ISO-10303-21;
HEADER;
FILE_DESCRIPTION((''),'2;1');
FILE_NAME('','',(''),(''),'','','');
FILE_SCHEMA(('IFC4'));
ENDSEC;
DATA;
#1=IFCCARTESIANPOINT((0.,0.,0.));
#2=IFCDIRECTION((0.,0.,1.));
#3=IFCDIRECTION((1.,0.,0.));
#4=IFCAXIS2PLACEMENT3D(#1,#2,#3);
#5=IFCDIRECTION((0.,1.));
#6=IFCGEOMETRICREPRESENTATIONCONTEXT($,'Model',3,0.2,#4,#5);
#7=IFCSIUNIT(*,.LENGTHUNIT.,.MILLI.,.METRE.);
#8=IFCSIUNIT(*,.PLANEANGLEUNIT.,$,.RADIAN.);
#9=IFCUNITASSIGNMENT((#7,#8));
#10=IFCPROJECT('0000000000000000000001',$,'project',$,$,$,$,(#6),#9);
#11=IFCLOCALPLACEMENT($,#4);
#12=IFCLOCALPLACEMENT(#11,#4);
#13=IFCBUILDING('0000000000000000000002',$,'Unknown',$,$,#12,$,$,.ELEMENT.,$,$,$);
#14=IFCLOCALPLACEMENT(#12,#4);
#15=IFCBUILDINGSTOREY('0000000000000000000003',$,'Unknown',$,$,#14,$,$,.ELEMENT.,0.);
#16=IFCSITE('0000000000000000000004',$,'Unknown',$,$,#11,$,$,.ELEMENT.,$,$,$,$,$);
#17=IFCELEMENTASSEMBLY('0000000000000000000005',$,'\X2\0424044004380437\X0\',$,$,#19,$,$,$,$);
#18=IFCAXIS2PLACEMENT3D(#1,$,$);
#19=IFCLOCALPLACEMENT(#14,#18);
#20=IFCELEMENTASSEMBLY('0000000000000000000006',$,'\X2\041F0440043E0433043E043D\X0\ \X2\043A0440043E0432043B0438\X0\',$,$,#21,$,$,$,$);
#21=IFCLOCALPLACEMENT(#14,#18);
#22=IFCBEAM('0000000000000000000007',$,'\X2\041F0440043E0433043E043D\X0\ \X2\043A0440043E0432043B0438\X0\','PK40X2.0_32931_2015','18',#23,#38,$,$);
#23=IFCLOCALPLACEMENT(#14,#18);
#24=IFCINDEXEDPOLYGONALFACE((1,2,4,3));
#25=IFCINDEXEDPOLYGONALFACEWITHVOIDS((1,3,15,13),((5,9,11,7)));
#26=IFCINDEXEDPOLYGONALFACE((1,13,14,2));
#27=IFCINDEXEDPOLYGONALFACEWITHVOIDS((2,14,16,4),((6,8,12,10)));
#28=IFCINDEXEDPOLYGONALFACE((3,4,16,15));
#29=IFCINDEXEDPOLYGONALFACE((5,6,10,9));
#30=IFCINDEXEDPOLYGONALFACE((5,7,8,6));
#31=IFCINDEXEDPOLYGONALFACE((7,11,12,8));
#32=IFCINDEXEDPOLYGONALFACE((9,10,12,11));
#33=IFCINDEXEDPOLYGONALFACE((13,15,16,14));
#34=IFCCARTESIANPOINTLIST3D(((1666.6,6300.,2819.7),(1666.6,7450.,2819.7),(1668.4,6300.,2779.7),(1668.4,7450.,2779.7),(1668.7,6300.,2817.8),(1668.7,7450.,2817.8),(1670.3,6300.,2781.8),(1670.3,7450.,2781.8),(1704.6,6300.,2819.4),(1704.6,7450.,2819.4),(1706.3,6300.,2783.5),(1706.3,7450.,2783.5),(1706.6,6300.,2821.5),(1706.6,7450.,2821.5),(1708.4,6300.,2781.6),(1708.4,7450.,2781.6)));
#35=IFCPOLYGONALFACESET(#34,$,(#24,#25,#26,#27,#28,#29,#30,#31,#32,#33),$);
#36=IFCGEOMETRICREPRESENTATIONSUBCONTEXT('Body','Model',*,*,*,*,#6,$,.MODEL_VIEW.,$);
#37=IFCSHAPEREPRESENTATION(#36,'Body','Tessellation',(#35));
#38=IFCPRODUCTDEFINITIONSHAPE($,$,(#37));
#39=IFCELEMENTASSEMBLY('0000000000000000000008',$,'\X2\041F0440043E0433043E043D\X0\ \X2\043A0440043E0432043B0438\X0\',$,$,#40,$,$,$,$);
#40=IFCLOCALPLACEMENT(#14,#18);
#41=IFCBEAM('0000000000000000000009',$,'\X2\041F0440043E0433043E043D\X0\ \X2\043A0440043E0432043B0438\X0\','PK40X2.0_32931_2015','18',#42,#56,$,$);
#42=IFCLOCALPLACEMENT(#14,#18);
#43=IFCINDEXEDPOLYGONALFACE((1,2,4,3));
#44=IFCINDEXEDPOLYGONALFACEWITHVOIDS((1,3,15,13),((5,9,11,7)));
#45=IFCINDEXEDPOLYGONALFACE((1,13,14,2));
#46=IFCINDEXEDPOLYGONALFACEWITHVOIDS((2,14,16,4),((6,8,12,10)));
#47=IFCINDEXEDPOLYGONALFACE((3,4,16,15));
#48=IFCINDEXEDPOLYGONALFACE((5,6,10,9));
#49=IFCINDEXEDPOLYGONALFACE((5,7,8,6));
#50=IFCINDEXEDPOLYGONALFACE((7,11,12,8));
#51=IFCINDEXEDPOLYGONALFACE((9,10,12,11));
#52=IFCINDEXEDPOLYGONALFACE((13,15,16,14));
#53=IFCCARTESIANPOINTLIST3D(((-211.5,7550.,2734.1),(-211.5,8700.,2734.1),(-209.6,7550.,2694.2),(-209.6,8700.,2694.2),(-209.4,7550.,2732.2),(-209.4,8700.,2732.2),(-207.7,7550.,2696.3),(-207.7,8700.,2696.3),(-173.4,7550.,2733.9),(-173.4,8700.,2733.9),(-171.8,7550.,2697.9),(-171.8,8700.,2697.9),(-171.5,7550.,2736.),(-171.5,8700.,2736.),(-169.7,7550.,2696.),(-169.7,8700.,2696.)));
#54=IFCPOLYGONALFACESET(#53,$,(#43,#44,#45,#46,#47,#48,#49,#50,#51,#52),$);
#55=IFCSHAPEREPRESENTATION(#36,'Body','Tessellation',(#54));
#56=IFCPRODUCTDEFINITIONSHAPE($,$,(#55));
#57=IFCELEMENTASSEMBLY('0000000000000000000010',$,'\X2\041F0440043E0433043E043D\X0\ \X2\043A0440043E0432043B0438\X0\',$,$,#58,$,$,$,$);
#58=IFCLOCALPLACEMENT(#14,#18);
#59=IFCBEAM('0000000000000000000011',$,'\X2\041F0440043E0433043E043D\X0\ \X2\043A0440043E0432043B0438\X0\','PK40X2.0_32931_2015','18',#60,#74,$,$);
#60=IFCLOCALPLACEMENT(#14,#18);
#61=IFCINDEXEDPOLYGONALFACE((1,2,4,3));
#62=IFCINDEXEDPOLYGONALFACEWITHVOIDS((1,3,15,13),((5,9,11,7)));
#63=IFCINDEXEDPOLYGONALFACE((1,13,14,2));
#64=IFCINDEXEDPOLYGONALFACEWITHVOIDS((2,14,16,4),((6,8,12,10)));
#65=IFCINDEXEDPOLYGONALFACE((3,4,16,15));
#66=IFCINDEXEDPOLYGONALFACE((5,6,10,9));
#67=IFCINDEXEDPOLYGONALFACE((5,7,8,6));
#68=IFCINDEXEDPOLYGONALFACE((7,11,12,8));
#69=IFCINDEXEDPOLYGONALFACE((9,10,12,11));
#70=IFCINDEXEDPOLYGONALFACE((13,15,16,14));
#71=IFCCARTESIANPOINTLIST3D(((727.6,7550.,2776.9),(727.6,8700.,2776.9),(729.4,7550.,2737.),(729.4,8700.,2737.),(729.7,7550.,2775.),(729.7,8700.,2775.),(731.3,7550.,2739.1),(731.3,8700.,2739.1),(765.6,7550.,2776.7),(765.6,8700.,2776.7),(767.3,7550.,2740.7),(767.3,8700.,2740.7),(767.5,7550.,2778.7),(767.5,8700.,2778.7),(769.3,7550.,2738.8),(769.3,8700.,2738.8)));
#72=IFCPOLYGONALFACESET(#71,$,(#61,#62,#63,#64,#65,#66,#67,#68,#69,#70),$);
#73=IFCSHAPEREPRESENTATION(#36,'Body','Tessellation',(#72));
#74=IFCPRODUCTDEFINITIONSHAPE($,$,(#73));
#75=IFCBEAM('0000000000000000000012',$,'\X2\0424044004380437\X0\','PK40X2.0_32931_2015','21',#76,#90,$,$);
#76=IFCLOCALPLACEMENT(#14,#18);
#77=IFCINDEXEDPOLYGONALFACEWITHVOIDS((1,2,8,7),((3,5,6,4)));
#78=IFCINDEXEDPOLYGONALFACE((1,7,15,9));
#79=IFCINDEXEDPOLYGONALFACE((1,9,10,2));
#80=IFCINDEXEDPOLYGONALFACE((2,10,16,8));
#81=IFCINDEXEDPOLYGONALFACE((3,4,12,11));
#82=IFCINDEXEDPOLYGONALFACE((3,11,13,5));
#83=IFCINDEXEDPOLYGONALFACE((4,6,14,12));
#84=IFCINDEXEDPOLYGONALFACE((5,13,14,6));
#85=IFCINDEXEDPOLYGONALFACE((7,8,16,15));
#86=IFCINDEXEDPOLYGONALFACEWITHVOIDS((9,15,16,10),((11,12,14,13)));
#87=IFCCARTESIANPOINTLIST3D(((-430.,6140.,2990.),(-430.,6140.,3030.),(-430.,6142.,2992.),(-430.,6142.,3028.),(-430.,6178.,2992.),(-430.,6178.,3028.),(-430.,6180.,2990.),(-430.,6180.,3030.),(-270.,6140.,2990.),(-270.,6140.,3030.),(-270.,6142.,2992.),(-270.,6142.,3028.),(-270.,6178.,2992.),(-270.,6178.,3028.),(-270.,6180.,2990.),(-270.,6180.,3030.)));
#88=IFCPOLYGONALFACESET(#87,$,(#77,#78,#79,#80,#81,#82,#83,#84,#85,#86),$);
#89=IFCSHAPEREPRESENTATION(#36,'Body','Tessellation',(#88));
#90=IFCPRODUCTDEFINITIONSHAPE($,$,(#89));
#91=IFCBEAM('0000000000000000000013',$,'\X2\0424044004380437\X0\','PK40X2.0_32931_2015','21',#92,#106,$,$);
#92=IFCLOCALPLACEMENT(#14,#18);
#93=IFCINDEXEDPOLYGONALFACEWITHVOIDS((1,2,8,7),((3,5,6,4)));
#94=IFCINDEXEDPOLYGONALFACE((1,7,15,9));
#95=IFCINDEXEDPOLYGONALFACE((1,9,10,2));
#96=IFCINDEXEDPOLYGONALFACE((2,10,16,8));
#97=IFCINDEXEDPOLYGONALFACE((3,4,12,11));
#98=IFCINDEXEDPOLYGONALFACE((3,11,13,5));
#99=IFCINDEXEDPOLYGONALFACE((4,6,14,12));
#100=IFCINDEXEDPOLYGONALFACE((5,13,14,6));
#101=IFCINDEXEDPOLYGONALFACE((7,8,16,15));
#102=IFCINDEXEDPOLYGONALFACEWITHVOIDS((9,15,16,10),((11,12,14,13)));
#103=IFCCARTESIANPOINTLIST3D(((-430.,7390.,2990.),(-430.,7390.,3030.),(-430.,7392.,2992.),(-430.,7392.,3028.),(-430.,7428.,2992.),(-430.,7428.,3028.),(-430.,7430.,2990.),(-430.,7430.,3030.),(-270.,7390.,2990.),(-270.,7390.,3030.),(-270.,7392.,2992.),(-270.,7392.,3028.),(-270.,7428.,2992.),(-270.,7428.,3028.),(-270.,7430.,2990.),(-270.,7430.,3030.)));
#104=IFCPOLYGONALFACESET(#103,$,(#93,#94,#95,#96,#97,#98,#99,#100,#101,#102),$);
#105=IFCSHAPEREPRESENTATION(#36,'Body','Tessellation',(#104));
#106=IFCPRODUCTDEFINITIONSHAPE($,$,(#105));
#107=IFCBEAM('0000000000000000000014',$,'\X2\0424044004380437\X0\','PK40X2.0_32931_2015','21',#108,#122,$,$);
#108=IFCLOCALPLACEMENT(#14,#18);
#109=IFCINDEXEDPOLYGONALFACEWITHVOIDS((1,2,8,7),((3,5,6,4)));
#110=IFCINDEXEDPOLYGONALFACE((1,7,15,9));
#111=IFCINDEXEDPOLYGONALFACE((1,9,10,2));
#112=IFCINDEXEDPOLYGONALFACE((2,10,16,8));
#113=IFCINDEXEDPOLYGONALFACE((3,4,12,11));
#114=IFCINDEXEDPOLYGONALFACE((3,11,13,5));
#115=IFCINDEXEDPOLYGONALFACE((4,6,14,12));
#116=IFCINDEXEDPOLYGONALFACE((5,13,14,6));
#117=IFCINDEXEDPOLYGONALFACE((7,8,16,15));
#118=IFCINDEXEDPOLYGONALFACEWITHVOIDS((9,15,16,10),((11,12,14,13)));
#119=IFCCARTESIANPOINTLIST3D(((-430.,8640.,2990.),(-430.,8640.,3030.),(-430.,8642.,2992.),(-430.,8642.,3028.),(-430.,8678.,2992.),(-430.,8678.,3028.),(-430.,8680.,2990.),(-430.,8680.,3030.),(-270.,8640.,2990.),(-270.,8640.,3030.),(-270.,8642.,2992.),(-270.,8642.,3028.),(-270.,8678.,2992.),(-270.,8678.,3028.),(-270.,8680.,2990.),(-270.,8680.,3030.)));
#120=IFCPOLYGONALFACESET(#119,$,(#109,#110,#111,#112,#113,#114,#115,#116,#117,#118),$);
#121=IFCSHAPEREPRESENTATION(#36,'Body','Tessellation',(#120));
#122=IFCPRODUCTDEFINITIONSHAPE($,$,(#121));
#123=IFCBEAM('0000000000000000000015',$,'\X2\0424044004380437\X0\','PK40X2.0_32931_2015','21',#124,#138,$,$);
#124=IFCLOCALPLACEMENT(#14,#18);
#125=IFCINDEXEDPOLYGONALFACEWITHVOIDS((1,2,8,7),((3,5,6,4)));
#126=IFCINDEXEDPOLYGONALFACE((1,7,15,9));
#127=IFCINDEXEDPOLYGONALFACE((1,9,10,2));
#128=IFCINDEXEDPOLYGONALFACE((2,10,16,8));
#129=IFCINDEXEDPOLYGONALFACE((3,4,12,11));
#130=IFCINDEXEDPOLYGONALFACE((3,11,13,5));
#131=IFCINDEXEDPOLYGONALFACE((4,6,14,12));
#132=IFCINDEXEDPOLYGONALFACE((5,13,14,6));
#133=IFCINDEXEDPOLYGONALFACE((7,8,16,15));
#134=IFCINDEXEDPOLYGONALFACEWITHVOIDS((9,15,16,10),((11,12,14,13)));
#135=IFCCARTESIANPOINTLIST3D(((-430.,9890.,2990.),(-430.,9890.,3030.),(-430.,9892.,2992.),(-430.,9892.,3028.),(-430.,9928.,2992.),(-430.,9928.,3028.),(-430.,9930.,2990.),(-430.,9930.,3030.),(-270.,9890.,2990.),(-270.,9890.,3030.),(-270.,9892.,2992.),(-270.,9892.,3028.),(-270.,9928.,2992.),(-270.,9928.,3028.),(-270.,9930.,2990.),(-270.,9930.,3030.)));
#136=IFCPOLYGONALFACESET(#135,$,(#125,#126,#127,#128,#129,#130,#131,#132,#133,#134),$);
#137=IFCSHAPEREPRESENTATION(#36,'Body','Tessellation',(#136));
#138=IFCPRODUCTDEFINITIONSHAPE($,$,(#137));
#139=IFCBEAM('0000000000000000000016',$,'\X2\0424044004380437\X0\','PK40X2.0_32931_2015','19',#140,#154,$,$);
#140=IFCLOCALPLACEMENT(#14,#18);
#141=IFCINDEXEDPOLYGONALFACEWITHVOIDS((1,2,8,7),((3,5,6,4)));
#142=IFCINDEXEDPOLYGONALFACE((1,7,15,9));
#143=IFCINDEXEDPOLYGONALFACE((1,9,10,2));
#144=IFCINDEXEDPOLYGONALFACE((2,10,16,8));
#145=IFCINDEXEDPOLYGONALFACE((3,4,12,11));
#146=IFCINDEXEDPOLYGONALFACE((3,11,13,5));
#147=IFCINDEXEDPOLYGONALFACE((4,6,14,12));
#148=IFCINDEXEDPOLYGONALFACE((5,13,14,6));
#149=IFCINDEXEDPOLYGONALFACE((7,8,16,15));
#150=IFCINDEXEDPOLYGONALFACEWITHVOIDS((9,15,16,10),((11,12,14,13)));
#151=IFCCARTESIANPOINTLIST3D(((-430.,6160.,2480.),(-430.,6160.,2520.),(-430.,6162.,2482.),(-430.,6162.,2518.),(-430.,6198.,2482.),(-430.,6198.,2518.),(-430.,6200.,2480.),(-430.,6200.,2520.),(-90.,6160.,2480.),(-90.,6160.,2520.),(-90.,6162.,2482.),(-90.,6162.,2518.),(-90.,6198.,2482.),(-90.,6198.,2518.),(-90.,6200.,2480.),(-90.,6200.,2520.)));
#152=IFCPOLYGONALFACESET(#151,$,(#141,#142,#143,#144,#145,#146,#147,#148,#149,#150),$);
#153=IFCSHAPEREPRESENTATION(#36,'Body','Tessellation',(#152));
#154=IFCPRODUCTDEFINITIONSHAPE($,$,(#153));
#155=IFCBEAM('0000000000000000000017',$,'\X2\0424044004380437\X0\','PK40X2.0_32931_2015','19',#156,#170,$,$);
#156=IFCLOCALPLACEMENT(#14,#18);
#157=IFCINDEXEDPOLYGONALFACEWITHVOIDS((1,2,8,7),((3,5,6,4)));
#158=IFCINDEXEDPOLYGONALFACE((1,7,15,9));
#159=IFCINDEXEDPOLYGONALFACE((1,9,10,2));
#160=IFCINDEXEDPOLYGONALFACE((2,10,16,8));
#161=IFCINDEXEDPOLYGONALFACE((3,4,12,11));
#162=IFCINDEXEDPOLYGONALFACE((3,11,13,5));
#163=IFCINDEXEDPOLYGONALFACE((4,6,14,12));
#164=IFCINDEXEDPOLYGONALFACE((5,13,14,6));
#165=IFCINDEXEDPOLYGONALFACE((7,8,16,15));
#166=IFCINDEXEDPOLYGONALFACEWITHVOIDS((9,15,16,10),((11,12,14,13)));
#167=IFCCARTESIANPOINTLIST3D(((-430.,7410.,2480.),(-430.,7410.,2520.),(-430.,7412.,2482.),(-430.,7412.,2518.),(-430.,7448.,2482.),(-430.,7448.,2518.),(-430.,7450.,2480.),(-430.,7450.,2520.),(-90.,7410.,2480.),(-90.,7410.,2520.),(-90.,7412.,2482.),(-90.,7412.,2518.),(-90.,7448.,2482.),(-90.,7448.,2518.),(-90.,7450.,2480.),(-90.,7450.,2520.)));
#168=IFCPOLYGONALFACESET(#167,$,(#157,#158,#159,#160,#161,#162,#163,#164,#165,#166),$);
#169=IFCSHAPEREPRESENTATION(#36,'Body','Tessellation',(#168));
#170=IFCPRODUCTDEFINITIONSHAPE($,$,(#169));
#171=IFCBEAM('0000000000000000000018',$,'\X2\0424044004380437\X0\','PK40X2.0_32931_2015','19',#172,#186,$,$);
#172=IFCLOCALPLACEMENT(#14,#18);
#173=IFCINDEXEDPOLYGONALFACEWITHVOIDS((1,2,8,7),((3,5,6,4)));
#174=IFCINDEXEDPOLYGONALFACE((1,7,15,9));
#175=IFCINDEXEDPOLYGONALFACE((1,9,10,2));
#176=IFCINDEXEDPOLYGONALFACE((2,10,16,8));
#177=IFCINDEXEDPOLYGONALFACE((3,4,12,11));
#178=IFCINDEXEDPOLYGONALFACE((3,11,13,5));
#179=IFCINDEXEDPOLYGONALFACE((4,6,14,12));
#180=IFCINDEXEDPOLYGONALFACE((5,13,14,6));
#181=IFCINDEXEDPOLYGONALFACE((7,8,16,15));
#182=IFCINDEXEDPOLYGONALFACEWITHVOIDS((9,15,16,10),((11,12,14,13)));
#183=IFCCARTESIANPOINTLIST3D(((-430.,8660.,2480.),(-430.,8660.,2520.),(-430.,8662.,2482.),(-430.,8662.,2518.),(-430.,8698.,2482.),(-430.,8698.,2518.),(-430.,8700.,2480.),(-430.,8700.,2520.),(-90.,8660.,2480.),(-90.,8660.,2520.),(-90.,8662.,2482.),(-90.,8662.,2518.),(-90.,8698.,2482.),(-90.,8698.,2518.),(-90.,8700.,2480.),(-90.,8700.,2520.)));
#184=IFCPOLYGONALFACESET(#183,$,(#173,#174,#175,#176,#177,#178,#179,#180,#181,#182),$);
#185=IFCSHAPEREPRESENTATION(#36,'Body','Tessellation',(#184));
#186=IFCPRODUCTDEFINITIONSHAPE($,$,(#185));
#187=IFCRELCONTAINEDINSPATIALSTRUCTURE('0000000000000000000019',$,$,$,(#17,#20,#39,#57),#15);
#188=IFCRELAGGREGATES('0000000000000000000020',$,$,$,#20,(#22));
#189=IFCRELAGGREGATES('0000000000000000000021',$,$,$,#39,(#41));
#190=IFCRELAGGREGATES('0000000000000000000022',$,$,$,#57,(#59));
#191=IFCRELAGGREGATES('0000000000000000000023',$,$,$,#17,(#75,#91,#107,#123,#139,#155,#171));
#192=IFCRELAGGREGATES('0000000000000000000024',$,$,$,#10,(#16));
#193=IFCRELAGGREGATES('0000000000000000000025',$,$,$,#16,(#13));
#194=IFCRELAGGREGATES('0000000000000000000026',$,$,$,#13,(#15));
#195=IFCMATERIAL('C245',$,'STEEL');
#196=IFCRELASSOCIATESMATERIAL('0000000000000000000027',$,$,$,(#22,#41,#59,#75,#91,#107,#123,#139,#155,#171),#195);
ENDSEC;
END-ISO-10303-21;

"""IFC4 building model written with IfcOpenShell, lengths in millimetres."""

from ifc_helpers import new_model, si_unit, direction, frame, origin_with_axes, place, context, subcontext, project, spatial, line, indexed_curve, outline, extrude, material, element, aggregate, save


model = new_model("IFC4")

# Units and contexts
model_context = context("Model", 3, precision=0.2, world=origin_with_axes(), true_north=direction((0.0, 1.0)))
body_context = subcontext(model_context, "Body", "Model", "MODEL_VIEW")
ifc_project = project(units=[si_unit("LENGTHUNIT", "METRE", prefix="MILLI"), si_unit("PLANEANGLEUNIT", "RADIAN")], contexts=[model_context])

# Site, building, storey
site_placement = place(None, origin_with_axes())
site = spatial("IfcSite", under=ifc_project, at=site_placement, Name="Unknown", CompositionType="ELEMENT")
building_placement = place(site_placement, origin_with_axes())
building = spatial("IfcBuilding", under=site, at=building_placement, Name="Unknown", CompositionType="ELEMENT")
storey_placement = place(building_placement, origin_with_axes())
storey = spatial("IfcBuildingStorey", under=building, at=storey_placement, Name="Unknown", CompositionType="ELEMENT", Elevation=0.0)

# Element assembly
assembly_1_placement = place(storey_placement, frame((-450.0, -500.0, 3010.0), z_axis=(1.0, 0.0, 0.0), x_axis=(0.0, 1.0, 0.0)))
assembly_1 = element("IfcElementAssembly", 1, at=assembly_1_placement, inside=storey, Name="Фриз")
ifc_material = material(Name="C245", Category="STEEL")

# Element assemblies, beams
assembly_2_placement = place(storey_placement, frame((1687.5, 7450.0, 2800.6), z_axis=(-0.998964, 0.0, -0.045508), x_axis=(0.0, -1.0, 0.0)))
assembly_2 = element("IfcElementAssembly", 2, at=assembly_2_placement, inside=storey, Name="Прогон кровли")
beam_1_placement = place(assembly_2_placement, origin_with_axes())
beam_1 = element("IfcBeam", 3, at=beam_1_placement, material=ifc_material, Name="Прогон кровли", Description="PK40X2.0_32931_2015", ObjectType="18", context=body_context, shape_type="SolidModel", body=[
    extrude(outline(indexed_curve([(-20.0, -20.0), (20.0, -20.0), (20.0, 20.0), (-20.0, 20.0)], segments=[line(1, 2, 3, 4, 1)]), holes=[indexed_curve([(-18.0, -18.0), (-18.0, 18.0), (18.0, 18.0), (18.0, -18.0)], segments=[line(1, 2, 3, 4, 1)])]), frame((0.0, 0.0, 0.0), z_axis=(-1.0, 0.0, 0.0), x_axis=(0.0, 0.0, 1.0)), (0.0, 0.0, -1.0), 1150.0),
])
aggregate(assembly_2, [beam_1])
assembly_3_placement = place(storey_placement, frame((-190.6, 8700.0, 2715.1), z_axis=(-0.998964, 0.0, -0.045508), x_axis=(0.0, -1.0, 0.0)))
assembly_3 = element("IfcElementAssembly", 4, at=assembly_3_placement, inside=storey, Name="Прогон кровли")
beam_2_placement = place(assembly_3_placement, origin_with_axes())
beam_2 = element("IfcBeam", 5, at=beam_2_placement, material=ifc_material, Name="Прогон кровли", Description="PK40X2.0_32931_2015", ObjectType="18", context=body_context, shape_type="SolidModel", body=[
    extrude(outline(indexed_curve([(-20.0, -20.0), (20.0, -20.0), (20.0, 20.0), (-20.0, 20.0)], segments=[line(1, 2, 3, 4, 1)]), holes=[indexed_curve([(-18.0, -18.0), (-18.0, 18.0), (18.0, 18.0), (18.0, -18.0)], segments=[line(1, 2, 3, 4, 1)])]), frame((0.0, 0.0, 0.0), z_axis=(-1.0, 0.0, 0.0), x_axis=(0.0, 0.0, 1.0)), (0.0, 0.0, -1.0), 1150.0),
])
aggregate(assembly_3, [beam_2])
assembly_4_placement = place(storey_placement, frame((748.5, 8700.0, 2757.9), z_axis=(-0.998964, 0.0, -0.045508), x_axis=(0.0, -1.0, 0.0)))
assembly_4 = element("IfcElementAssembly", 6, at=assembly_4_placement, inside=storey, Name="Прогон кровли")
beam_3_placement = place(assembly_4_placement, origin_with_axes())
beam_3 = element("IfcBeam", 7, at=beam_3_placement, material=ifc_material, Name="Прогон кровли", Description="PK40X2.0_32931_2015", ObjectType="18", context=body_context, shape_type="SolidModel", body=[
    extrude(outline(indexed_curve([(-20.0, -20.0), (20.0, -20.0), (20.0, 20.0), (-20.0, 20.0)], segments=[line(1, 2, 3, 4, 1)]), holes=[indexed_curve([(-18.0, -18.0), (-18.0, 18.0), (18.0, 18.0), (18.0, -18.0)], segments=[line(1, 2, 3, 4, 1)])]), frame((0.0, 0.0, 0.0), z_axis=(-1.0, 0.0, 0.0), x_axis=(0.0, 0.0, 1.0)), (0.0, 0.0, -1.0), 1150.0),
])
aggregate(assembly_4, [beam_3])

# Beams
beam_4_placement = place(assembly_1_placement, frame((6660.0, 0.0, 20.0), z_axis=(-1.0, 0.0, 0.0), x_axis=(0.0, 0.0, 1.0)))
beam_4 = element("IfcBeam", 8, at=beam_4_placement, material=ifc_material, Name="Фриз", Description="PK40X2.0_32931_2015", ObjectType="21", context=body_context, shape_type="SolidModel", body=[
    extrude(outline(indexed_curve([(-20.0, -20.0), (20.0, -20.0), (20.0, 20.0), (-20.0, 20.0)], segments=[line(1, 2, 3, 4, 1)]), holes=[indexed_curve([(-18.0, -18.0), (-18.0, 18.0), (18.0, 18.0), (18.0, -18.0)], segments=[line(1, 2, 3, 4, 1)])]), frame((0.0, 0.0, 0.0), z_axis=(-1.0, 0.0, 0.0), x_axis=(0.0, 0.0, 1.0)), (0.0, 0.0, -1.0), 160.0),
])
beam_5_placement = place(assembly_1_placement, frame((7910.0, 0.0, 20.0), z_axis=(-1.0, 0.0, 0.0), x_axis=(0.0, 0.0, 1.0)))
beam_5 = element("IfcBeam", 9, at=beam_5_placement, material=ifc_material, Name="Фриз", Description="PK40X2.0_32931_2015", ObjectType="21", context=body_context, shape_type="SolidModel", body=[
    extrude(outline(indexed_curve([(-20.0, -20.0), (20.0, -20.0), (20.0, 20.0), (-20.0, 20.0)], segments=[line(1, 2, 3, 4, 1)]), holes=[indexed_curve([(-18.0, -18.0), (-18.0, 18.0), (18.0, 18.0), (18.0, -18.0)], segments=[line(1, 2, 3, 4, 1)])]), frame((0.0, 0.0, 0.0), z_axis=(-1.0, 0.0, 0.0), x_axis=(0.0, 0.0, 1.0)), (0.0, 0.0, -1.0), 160.0),
])
beam_6_placement = place(assembly_1_placement, frame((9160.0, 0.0, 20.0), z_axis=(-1.0, 0.0, 0.0), x_axis=(0.0, 0.0, 1.0)))
beam_6 = element("IfcBeam", 10, at=beam_6_placement, material=ifc_material, Name="Фриз", Description="PK40X2.0_32931_2015", ObjectType="21", context=body_context, shape_type="SolidModel", body=[
    extrude(outline(indexed_curve([(-20.0, -20.0), (20.0, -20.0), (20.0, 20.0), (-20.0, 20.0)], segments=[line(1, 2, 3, 4, 1)]), holes=[indexed_curve([(-18.0, -18.0), (-18.0, 18.0), (18.0, 18.0), (18.0, -18.0)], segments=[line(1, 2, 3, 4, 1)])]), frame((0.0, 0.0, 0.0), z_axis=(-1.0, 0.0, 0.0), x_axis=(0.0, 0.0, 1.0)), (0.0, 0.0, -1.0), 160.0),
])
beam_7_placement = place(assembly_1_placement, frame((10410.0, 0.0, 20.0), z_axis=(-1.0, 0.0, 0.0), x_axis=(0.0, 0.0, 1.0)))
beam_7 = element("IfcBeam", 11, at=beam_7_placement, material=ifc_material, Name="Фриз", Description="PK40X2.0_32931_2015", ObjectType="21", context=body_context, shape_type="SolidModel", body=[
    extrude(outline(indexed_curve([(-20.0, -20.0), (20.0, -20.0), (20.0, 20.0), (-20.0, 20.0)], segments=[line(1, 2, 3, 4, 1)]), holes=[indexed_curve([(-18.0, -18.0), (-18.0, 18.0), (18.0, 18.0), (18.0, -18.0)], segments=[line(1, 2, 3, 4, 1)])]), frame((0.0, 0.0, 0.0), z_axis=(-1.0, 0.0, 0.0), x_axis=(0.0, 0.0, 1.0)), (0.0, 0.0, -1.0), 160.0),
])
beam_8_placement = place(assembly_1_placement, frame((6680.0, -510.0, 20.0), z_axis=(-1.0, 0.0, 0.0), x_axis=(0.0, 0.0, 1.0)))
beam_8 = element("IfcBeam", 12, at=beam_8_placement, material=ifc_material, Name="Фриз", Description="PK40X2.0_32931_2015", ObjectType="19", context=body_context, shape_type="SolidModel", body=[
    extrude(outline(indexed_curve([(-20.0, -20.0), (20.0, -20.0), (20.0, 20.0), (-20.0, 20.0)], segments=[line(1, 2, 3, 4, 1)]), holes=[indexed_curve([(-18.0, -18.0), (-18.0, 18.0), (18.0, 18.0), (18.0, -18.0)], segments=[line(1, 2, 3, 4, 1)])]), frame((0.0, 0.0, 0.0), z_axis=(-1.0, 0.0, 0.0), x_axis=(0.0, 0.0, 1.0)), (0.0, 0.0, -1.0), 340.0),
])
beam_9_placement = place(assembly_1_placement, frame((7930.0, -510.0, 20.0), z_axis=(-1.0, 0.0, 0.0), x_axis=(0.0, 0.0, 1.0)))
beam_9 = element("IfcBeam", 13, at=beam_9_placement, material=ifc_material, Name="Фриз", Description="PK40X2.0_32931_2015", ObjectType="19", context=body_context, shape_type="SolidModel", body=[
    extrude(outline(indexed_curve([(-20.0, -20.0), (20.0, -20.0), (20.0, 20.0), (-20.0, 20.0)], segments=[line(1, 2, 3, 4, 1)]), holes=[indexed_curve([(-18.0, -18.0), (-18.0, 18.0), (18.0, 18.0), (18.0, -18.0)], segments=[line(1, 2, 3, 4, 1)])]), frame((0.0, 0.0, 0.0), z_axis=(-1.0, 0.0, 0.0), x_axis=(0.0, 0.0, 1.0)), (0.0, 0.0, -1.0), 340.0),
])
beam_10_placement = place(assembly_1_placement, frame((9180.0, -510.0, 20.0), z_axis=(-1.0, 0.0, 0.0), x_axis=(0.0, 0.0, 1.0)))
beam_10 = element("IfcBeam", 14, at=beam_10_placement, material=ifc_material, Name="Фриз", Description="PK40X2.0_32931_2015", ObjectType="19", context=body_context, shape_type="SolidModel", body=[
    extrude(outline(indexed_curve([(-20.0, -20.0), (20.0, -20.0), (20.0, 20.0), (-20.0, 20.0)], segments=[line(1, 2, 3, 4, 1)]), holes=[indexed_curve([(-18.0, -18.0), (-18.0, 18.0), (18.0, 18.0), (18.0, -18.0)], segments=[line(1, 2, 3, 4, 1)])]), frame((0.0, 0.0, 0.0), z_axis=(-1.0, 0.0, 0.0), x_axis=(0.0, 0.0, 1.0)), (0.0, 0.0, -1.0), 340.0),
])
aggregate(assembly_1, [beam_4, beam_5, beam_6, beam_7, beam_8, beam_9, beam_10])

save(model, "model.ifc")
